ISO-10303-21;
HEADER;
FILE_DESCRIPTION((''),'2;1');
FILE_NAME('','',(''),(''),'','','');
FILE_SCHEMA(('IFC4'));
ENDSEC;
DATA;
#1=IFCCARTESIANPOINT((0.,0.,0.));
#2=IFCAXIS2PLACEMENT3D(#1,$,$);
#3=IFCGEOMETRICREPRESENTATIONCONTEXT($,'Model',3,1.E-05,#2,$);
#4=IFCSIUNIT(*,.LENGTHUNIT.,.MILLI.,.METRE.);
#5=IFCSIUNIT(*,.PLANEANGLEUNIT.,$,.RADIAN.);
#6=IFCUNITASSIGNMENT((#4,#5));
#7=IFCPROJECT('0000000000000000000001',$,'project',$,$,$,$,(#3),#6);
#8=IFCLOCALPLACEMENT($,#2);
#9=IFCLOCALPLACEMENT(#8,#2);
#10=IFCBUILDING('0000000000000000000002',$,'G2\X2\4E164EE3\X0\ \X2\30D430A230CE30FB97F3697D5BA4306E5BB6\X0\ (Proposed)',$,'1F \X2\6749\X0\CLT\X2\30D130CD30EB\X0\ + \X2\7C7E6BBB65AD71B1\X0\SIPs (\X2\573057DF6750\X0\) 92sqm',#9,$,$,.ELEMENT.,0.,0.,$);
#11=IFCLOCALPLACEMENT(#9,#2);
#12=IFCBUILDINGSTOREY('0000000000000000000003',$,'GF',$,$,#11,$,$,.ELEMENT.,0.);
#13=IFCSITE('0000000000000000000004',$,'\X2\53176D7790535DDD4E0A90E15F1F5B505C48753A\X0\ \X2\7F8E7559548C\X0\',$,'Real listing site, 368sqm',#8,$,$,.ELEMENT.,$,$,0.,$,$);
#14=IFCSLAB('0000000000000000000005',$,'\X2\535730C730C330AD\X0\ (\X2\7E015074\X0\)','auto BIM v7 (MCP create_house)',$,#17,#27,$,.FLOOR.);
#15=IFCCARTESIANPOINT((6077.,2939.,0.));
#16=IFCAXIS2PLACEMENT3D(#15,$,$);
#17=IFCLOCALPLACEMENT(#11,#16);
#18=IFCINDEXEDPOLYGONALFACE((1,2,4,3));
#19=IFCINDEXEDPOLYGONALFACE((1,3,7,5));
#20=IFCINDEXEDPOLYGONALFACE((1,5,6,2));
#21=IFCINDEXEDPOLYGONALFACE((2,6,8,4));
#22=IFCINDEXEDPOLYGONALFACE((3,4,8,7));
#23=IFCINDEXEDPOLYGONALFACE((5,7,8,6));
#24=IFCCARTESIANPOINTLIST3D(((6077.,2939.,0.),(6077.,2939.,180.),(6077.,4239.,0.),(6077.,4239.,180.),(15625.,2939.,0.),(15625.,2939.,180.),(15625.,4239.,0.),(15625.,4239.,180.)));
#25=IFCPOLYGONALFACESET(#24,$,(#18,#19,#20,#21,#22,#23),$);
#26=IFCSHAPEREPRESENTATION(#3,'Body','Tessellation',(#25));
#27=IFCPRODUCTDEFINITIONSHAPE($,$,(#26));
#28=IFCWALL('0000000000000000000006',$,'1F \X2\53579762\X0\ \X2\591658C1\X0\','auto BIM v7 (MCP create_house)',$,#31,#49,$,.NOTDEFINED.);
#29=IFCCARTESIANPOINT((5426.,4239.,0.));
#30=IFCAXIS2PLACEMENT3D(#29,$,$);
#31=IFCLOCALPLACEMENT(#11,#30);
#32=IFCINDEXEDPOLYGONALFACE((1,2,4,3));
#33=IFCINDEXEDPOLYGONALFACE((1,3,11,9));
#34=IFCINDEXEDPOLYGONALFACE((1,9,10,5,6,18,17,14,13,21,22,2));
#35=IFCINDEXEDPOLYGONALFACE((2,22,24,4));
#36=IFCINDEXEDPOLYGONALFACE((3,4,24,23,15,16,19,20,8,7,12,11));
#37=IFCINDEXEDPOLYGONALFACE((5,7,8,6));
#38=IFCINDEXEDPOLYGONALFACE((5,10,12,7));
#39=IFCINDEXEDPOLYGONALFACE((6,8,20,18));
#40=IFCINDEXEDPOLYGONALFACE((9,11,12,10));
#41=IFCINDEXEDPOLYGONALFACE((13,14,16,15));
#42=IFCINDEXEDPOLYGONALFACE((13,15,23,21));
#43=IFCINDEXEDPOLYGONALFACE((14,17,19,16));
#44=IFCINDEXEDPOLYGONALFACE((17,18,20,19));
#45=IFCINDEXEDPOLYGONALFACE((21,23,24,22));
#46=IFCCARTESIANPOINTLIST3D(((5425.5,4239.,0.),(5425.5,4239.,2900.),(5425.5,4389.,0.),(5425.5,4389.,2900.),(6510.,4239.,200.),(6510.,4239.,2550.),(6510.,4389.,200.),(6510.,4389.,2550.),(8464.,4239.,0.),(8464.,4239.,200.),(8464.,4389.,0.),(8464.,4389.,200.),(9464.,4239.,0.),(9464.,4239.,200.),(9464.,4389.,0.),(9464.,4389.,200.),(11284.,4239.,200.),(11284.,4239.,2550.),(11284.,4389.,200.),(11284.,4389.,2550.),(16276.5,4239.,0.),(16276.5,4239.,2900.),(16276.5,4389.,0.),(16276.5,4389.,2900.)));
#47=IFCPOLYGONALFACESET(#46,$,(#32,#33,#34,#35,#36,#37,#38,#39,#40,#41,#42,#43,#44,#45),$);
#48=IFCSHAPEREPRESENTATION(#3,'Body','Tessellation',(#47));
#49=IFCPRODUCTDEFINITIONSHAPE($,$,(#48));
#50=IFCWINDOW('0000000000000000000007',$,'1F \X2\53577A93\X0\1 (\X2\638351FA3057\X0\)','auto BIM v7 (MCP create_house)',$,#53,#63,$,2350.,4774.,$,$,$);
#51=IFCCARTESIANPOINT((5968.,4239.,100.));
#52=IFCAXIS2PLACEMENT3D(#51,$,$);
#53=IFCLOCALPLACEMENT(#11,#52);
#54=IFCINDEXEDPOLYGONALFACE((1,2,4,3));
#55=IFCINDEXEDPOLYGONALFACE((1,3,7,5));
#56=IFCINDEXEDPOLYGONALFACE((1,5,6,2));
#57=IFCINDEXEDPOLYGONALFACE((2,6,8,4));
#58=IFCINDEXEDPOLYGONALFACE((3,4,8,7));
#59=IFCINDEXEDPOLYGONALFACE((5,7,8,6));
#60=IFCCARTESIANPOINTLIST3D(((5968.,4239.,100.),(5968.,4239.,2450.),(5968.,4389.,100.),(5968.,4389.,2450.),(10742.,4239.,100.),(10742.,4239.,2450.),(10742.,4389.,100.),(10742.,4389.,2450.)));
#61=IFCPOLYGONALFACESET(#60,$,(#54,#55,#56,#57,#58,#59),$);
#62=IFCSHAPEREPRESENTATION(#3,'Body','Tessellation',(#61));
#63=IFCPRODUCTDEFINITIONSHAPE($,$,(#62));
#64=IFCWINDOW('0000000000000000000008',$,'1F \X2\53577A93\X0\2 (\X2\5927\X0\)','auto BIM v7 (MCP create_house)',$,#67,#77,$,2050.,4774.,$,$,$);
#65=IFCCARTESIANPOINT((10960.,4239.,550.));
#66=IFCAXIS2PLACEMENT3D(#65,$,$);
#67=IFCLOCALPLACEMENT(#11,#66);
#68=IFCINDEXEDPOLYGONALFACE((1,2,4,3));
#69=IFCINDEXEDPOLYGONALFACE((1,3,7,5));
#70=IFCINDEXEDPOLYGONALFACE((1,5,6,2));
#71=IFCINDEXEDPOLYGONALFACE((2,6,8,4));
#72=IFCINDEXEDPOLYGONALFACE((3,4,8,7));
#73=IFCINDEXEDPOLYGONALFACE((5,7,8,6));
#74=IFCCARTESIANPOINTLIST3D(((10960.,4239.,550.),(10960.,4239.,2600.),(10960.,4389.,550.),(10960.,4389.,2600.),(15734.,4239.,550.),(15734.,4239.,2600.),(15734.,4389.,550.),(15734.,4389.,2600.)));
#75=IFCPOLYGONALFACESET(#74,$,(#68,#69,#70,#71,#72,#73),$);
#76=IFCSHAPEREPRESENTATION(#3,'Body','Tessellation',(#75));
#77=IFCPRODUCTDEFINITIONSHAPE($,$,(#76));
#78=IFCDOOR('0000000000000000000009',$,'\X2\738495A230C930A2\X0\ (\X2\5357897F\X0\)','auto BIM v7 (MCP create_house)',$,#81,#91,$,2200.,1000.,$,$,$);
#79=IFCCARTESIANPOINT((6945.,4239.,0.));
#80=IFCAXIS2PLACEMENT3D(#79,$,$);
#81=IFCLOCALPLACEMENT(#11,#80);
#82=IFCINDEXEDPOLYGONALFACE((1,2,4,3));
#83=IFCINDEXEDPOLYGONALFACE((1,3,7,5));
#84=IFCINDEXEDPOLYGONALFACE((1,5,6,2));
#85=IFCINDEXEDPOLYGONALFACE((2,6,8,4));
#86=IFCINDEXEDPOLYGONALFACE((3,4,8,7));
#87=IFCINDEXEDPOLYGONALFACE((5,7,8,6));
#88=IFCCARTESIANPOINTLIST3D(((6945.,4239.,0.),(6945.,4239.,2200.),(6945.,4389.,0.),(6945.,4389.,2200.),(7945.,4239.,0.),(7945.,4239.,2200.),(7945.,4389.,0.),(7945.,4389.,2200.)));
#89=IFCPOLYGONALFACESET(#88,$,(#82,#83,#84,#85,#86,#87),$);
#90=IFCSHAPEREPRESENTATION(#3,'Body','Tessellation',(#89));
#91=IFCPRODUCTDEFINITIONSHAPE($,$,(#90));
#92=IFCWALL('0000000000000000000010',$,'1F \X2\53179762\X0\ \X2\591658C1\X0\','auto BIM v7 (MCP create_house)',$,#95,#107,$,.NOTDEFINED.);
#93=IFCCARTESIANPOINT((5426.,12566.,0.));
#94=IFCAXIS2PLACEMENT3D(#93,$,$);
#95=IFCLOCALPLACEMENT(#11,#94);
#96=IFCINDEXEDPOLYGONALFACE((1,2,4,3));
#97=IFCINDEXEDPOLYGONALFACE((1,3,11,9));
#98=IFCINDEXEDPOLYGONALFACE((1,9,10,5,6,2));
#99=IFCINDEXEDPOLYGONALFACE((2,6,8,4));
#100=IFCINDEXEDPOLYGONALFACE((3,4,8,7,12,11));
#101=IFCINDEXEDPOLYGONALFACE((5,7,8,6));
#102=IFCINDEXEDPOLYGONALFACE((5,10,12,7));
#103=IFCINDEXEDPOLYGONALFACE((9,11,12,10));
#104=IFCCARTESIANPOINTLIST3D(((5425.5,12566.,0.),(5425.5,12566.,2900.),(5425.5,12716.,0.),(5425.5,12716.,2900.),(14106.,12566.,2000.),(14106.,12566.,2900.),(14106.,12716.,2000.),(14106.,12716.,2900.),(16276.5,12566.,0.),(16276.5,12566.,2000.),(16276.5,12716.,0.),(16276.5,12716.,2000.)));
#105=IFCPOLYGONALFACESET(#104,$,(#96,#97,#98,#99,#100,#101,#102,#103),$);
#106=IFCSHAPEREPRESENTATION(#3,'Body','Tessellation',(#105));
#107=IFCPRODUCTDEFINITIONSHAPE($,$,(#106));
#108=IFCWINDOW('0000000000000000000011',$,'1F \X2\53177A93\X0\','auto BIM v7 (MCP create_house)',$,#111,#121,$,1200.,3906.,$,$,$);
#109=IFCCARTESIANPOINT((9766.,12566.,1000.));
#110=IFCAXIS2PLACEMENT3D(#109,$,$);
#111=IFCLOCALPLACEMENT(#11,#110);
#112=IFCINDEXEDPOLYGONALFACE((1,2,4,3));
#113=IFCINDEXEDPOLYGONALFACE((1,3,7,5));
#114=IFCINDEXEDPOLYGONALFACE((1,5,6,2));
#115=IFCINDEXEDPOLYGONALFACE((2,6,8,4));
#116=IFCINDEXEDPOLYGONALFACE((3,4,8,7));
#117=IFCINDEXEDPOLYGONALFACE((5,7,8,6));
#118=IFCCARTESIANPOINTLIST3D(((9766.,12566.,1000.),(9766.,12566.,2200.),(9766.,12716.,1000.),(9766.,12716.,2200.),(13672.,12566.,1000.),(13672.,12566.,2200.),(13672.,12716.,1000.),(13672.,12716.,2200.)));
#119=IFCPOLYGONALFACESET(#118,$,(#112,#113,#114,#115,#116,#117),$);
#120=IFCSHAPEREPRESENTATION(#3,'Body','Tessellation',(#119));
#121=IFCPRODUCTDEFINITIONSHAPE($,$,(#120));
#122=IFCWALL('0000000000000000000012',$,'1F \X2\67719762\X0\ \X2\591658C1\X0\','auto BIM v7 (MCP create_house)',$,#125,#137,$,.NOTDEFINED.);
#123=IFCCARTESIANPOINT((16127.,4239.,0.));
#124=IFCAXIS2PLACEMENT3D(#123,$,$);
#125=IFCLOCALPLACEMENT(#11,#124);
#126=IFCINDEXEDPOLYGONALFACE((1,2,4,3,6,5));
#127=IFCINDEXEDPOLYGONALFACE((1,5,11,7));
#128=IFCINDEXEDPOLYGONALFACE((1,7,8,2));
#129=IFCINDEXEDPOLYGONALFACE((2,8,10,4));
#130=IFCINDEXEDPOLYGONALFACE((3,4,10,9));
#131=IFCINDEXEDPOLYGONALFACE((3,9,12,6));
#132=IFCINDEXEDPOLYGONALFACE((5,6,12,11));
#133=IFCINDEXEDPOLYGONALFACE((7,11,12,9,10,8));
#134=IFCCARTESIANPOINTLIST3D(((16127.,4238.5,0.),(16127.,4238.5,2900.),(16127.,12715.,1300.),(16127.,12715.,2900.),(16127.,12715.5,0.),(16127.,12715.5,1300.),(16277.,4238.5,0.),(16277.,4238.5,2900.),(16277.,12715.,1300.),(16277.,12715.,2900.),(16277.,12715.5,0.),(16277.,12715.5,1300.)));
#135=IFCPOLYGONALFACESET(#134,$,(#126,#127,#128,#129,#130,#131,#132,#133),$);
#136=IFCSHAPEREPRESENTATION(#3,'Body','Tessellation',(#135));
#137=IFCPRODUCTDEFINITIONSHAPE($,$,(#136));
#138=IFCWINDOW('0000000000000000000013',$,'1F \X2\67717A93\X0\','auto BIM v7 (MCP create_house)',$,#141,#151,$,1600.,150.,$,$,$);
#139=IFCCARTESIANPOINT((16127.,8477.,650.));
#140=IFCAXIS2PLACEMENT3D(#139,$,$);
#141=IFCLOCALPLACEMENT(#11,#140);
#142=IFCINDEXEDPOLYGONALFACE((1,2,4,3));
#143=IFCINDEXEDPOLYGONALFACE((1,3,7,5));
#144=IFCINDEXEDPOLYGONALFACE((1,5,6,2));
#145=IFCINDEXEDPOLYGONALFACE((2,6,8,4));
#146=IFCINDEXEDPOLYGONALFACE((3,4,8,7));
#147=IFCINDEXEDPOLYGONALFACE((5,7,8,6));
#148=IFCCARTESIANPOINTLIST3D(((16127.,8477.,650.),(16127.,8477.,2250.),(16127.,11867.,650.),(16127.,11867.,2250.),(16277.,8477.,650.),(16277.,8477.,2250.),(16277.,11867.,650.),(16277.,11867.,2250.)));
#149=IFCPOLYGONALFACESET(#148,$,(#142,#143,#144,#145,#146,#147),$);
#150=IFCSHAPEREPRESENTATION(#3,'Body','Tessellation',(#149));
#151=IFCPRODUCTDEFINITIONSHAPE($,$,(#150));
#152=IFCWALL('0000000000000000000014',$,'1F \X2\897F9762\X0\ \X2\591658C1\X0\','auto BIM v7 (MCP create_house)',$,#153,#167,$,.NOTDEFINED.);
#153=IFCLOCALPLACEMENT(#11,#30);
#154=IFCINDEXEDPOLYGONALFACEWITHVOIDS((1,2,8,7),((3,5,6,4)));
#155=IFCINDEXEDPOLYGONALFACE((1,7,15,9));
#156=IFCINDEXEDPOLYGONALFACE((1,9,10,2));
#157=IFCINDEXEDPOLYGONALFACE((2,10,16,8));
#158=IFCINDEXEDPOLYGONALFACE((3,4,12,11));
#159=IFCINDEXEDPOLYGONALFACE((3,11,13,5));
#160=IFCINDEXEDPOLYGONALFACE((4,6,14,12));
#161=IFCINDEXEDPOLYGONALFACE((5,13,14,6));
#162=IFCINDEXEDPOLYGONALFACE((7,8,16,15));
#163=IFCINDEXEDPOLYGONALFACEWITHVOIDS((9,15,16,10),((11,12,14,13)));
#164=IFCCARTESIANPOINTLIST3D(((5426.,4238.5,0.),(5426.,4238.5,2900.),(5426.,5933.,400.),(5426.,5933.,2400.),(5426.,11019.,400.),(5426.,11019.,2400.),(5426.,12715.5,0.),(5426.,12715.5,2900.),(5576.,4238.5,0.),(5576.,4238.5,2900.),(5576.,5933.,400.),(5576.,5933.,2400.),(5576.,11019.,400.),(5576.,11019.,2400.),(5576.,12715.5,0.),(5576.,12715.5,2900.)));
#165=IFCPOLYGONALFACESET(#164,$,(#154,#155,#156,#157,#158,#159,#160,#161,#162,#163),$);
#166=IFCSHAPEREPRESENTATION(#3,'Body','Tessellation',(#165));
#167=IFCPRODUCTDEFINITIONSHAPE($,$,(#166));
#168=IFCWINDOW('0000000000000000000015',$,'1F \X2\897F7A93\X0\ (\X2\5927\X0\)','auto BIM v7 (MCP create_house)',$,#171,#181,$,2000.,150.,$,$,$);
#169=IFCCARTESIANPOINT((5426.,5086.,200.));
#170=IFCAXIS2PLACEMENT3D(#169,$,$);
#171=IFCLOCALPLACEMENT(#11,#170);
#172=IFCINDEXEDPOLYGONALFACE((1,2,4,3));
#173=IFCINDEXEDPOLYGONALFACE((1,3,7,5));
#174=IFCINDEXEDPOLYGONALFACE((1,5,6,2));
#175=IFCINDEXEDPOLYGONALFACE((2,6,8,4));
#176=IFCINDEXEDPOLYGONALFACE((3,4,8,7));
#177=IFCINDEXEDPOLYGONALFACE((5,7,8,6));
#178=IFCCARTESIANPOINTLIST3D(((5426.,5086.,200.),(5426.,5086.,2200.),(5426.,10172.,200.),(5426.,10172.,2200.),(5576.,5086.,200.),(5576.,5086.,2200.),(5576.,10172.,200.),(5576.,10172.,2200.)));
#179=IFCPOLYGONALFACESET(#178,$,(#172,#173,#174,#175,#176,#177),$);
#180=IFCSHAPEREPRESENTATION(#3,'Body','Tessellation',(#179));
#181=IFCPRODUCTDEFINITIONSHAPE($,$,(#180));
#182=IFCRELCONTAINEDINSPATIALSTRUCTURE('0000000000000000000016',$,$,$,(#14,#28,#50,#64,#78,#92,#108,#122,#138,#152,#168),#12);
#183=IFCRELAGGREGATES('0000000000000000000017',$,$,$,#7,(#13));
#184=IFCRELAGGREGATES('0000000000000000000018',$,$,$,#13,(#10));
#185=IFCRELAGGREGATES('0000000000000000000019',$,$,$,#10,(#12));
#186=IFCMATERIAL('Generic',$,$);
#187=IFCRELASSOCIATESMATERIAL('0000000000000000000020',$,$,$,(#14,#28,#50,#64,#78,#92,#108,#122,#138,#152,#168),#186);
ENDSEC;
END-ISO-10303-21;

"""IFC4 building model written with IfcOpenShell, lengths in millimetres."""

from ifc_helpers import new_model, si_unit, frame, frame_2d, origin, place, context, project, spatial, rectangle, extrude, material, element, fill, save


model = new_model("IFC4")

# Units and contexts
model_context = context("Model", 3, precision=1e-05, world=origin())
ifc_project = project(units=[si_unit("LENGTHUNIT", "METRE", prefix="MILLI"), si_unit("PLANEANGLEUNIT", "RADIAN")], contexts=[model_context])

# Site, building, storey
site_placement = place(None, origin())
site = spatial("IfcSite", under=ifc_project, at=site_placement, Name="北海道川上郡弟子屈町 美留和", ObjectType="Real listing site, 368sqm", CompositionType="ELEMENT", RefElevation=0.0)
building_placement = place(site_placement, origin())
building = spatial("IfcBuilding", under=site, at=building_placement, Name="G2世代 ピアノ・音楽室の家 (Proposed)", ObjectType="1F 杉CLTパネル + 籾殻断熱SIPs (地域材) 92sqm", CompositionType="ELEMENT", ElevationOfRefHeight=0.0, ElevationOfTerrain=0.0)
storey_placement = place(building_placement, origin())
storey = spatial("IfcBuildingStorey", under=building, at=storey_placement, Name="GF", CompositionType="ELEMENT", Elevation=0.0)

# Slab
ifc_material = material(Name="Generic")
slab_1_placement = place(storey_placement, frame((6077.0, 2939.0, 0.0)))
element("IfcSlab", 1, at=slab_1_placement, inside=storey, material=ifc_material, Name="南デッキ (縁側)", Description="auto BIM v7 (MCP create_house)", PredefinedType="FLOOR", context=model_context, shape_type="SweptSolid", body=[
    extrude(rectangle(XDim=9548.0, YDim=1300.0, at=frame_2d((4774.0, 650.0))), frame((6077.0, 2939.0, 0.0)), (0.0, 0.0, 1.0), 180.0),
])

# Wall, openings, windows, door
wall_1_placement = place(storey_placement, frame((5426.0, 4239.0, 0.0)))
wall_1 = element("IfcWall", 2, at=wall_1_placement, inside=storey, material=ifc_material, Name="1F 南面 外壁", Description="auto BIM v7 (MCP create_house)", PredefinedType="NOTDEFINED", context=model_context, shape_type="SweptSolid", body=[
    extrude(rectangle(XDim=10851.0, YDim=150.0, at=frame_2d((5425.0, 75.0))), frame((5426.0, 4239.0, 0.0)), (0.0, 0.0, 1.0), 2900.0),
])
opening_1_placement = place(storey_placement, frame((5968.0, 4239.0, 100.0)))
opening_1 = element("IfcOpeningElement", 3, at=opening_1_placement, cuts=wall_1, PredefinedType="NOTDEFINED", context=model_context, shape_type="SweptSolid", body=[
    extrude(rectangle(XDim=4774.0, YDim=150.0, at=frame_2d((2387.0, 75.0))), frame((5968.0, 4239.0, 100.0)), (0.0, 0.0, 1.0), 2350.0),
])
opening_2_placement = place(storey_placement, frame((10960.0, 4239.0, 550.0)))
opening_2 = element("IfcOpeningElement", 4, at=opening_2_placement, cuts=wall_1, PredefinedType="NOTDEFINED", context=model_context, shape_type="SweptSolid", body=[
    extrude(rectangle(XDim=4774.0, YDim=150.0, at=frame_2d((2387.0, 75.0))), frame((10960.0, 4239.0, 550.0)), (0.0, 0.0, 1.0), 2050.0),
])
opening_3_placement = place(storey_placement, frame((6945.0, 4239.0, 0.0)))
opening_3 = element("IfcOpeningElement", 5, at=opening_3_placement, cuts=wall_1, PredefinedType="NOTDEFINED", context=model_context, shape_type="SweptSolid", body=[
    extrude(rectangle(XDim=1000.0, YDim=150.0, at=frame_2d((500.0, 75.0))), frame((6945.0, 4239.0, 0.0)), (0.0, 0.0, 1.0), 2200.0),
])
window_1_placement = place(storey_placement, frame((5968.0, 4239.0, 100.0)))
window_1 = element("IfcWindow", 6, at=window_1_placement, inside=storey, material=ifc_material, Name="1F 南窓1 (掃出し)", Description="auto BIM v7 (MCP create_house)", OverallHeight=2350.0, OverallWidth=4774.0, context=model_context, shape_type="SweptSolid", body=[
    extrude(rectangle(XDim=4774.0, YDim=150.0, at=frame_2d((2387.0, 75.0))), frame((5968.0, 4239.0, 100.0)), (0.0, 0.0, 1.0), 2350.0),
])
fill(opening_1, window_1)
window_2_placement = place(storey_placement, frame((10960.0, 4239.0, 550.0)))
window_2 = element("IfcWindow", 7, at=window_2_placement, inside=storey, material=ifc_material, Name="1F 南窓2 (大)", Description="auto BIM v7 (MCP create_house)", OverallHeight=2050.0, OverallWidth=4774.0, context=model_context, shape_type="SweptSolid", body=[
    extrude(rectangle(XDim=4774.0, YDim=150.0, at=frame_2d((2387.0, 75.0))), frame((10960.0, 4239.0, 550.0)), (0.0, 0.0, 1.0), 2050.0),
])
fill(opening_2, window_2)
door_placement = place(storey_placement, frame((6945.0, 4239.0, 0.0)))
door = element("IfcDoor", 8, at=door_placement, inside=storey, material=ifc_material, Name="玄関ドア (南西)", Description="auto BIM v7 (MCP create_house)", OverallHeight=2200.0, OverallWidth=1000.0, context=model_context, shape_type="SweptSolid", body=[
    extrude(rectangle(XDim=1000.0, YDim=150.0, at=frame_2d((500.0, 75.0))), frame((6945.0, 4239.0, 0.0)), (0.0, 0.0, 1.0), 2200.0),
])
fill(opening_3, door)

# Walls, openings, windows
wall_2_placement = place(storey_placement, frame((5426.0, 12566.0, 0.0)))
wall_2 = element("IfcWall", 9, at=wall_2_placement, inside=storey, material=ifc_material, Name="1F 北面 外壁", Description="auto BIM v7 (MCP create_house)", PredefinedType="NOTDEFINED", context=model_context, shape_type="SweptSolid", body=[
    extrude(rectangle(XDim=10851.0, YDim=150.0, at=frame_2d((5425.0, 75.0))), frame((5426.0, 12566.0, 0.0)), (0.0, 0.0, 1.0), 2900.0),
])
opening_4_placement = place(storey_placement, frame((9766.0, 12566.0, 1000.0)))
opening_4 = element("IfcOpeningElement", 10, at=opening_4_placement, cuts=wall_2, PredefinedType="NOTDEFINED", context=model_context, shape_type="SweptSolid", body=[
    extrude(rectangle(XDim=3906.0, YDim=150.0, at=frame_2d((1953.0, 75.0))), frame((9766.0, 12566.0, 1000.0)), (0.0, 0.0, 1.0), 1200.0),
])
window_3_placement = place(storey_placement, frame((9766.0, 12566.0, 1000.0)))
window_3 = element("IfcWindow", 11, at=window_3_placement, inside=storey, material=ifc_material, Name="1F 北窓", Description="auto BIM v7 (MCP create_house)", OverallHeight=1200.0, OverallWidth=3906.0, context=model_context, shape_type="SweptSolid", body=[
    extrude(rectangle(XDim=3906.0, YDim=150.0, at=frame_2d((1953.0, 75.0))), frame((9766.0, 12566.0, 1000.0)), (0.0, 0.0, 1.0), 1200.0),
])
fill(opening_4, window_3)
wall_3_placement = place(storey_placement, frame((16127.0, 4239.0, 0.0)))
wall_3 = element("IfcWall", 12, at=wall_3_placement, inside=storey, material=ifc_material, Name="1F 東面 外壁", Description="auto BIM v7 (MCP create_house)", PredefinedType="NOTDEFINED", context=model_context, shape_type="SweptSolid", body=[
    extrude(rectangle(XDim=150.0, YDim=8477.0, at=frame_2d((75.0, 4238.0))), frame((16127.0, 4239.0, 0.0)), (0.0, 0.0, 1.0), 2900.0),
])
opening_5_placement = place(storey_placement, frame((16127.0, 8477.0, 650.0)))
opening_5 = element("IfcOpeningElement", 13, at=opening_5_placement, cuts=wall_3, PredefinedType="NOTDEFINED", context=model_context, shape_type="SweptSolid", body=[
    extrude(rectangle(XDim=150.0, YDim=3390.0, at=frame_2d((75.0, 1695.0))), frame((16127.0, 8477.0, 650.0)), (0.0, 0.0, 1.0), 1600.0),
])
window_4_placement = place(storey_placement, frame((16127.0, 8477.0, 650.0)))
window_4 = element("IfcWindow", 14, at=window_4_placement, inside=storey, material=ifc_material, Name="1F 東窓", Description="auto BIM v7 (MCP create_house)", OverallHeight=1600.0, OverallWidth=150.0, context=model_context, shape_type="SweptSolid", body=[
    extrude(rectangle(XDim=150.0, YDim=3390.0, at=frame_2d((75.0, 1695.0))), frame((16127.0, 8477.0, 650.0)), (0.0, 0.0, 1.0), 1600.0),
])
fill(opening_5, window_4)
wall_4_placement = place(storey_placement, frame((5426.0, 4239.0, 0.0)))
wall_4 = element("IfcWall", 15, at=wall_4_placement, inside=storey, material=ifc_material, Name="1F 西面 外壁", Description="auto BIM v7 (MCP create_house)", PredefinedType="NOTDEFINED", context=model_context, shape_type="SweptSolid", body=[
    extrude(rectangle(XDim=150.0, YDim=8477.0, at=frame_2d((75.0, 4238.0))), frame((5426.0, 4239.0, 0.0)), (0.0, 0.0, 1.0), 2900.0),
])
opening_6_placement = place(storey_placement, frame((5426.0, 5086.0, 200.0)))
opening_6 = element("IfcOpeningElement", 16, at=opening_6_placement, cuts=wall_4, PredefinedType="NOTDEFINED", context=model_context, shape_type="SweptSolid", body=[
    extrude(rectangle(XDim=150.0, YDim=5086.0, at=frame_2d((75.0, 2543.0))), frame((5426.0, 5086.0, 200.0)), (0.0, 0.0, 1.0), 2000.0),
])
window_5_placement = place(storey_placement, frame((5426.0, 5086.0, 200.0)))
window_5 = element("IfcWindow", 17, at=window_5_placement, inside=storey, material=ifc_material, Name="1F 西窓 (大)", Description="auto BIM v7 (MCP create_house)", OverallHeight=2000.0, OverallWidth=150.0, context=model_context, shape_type="SweptSolid", body=[
    extrude(rectangle(XDim=150.0, YDim=5086.0, at=frame_2d((75.0, 2543.0))), frame((5426.0, 5086.0, 200.0)), (0.0, 0.0, 1.0), 2000.0),
])
fill(opening_6, window_5)

save(model, "model.ifc")
